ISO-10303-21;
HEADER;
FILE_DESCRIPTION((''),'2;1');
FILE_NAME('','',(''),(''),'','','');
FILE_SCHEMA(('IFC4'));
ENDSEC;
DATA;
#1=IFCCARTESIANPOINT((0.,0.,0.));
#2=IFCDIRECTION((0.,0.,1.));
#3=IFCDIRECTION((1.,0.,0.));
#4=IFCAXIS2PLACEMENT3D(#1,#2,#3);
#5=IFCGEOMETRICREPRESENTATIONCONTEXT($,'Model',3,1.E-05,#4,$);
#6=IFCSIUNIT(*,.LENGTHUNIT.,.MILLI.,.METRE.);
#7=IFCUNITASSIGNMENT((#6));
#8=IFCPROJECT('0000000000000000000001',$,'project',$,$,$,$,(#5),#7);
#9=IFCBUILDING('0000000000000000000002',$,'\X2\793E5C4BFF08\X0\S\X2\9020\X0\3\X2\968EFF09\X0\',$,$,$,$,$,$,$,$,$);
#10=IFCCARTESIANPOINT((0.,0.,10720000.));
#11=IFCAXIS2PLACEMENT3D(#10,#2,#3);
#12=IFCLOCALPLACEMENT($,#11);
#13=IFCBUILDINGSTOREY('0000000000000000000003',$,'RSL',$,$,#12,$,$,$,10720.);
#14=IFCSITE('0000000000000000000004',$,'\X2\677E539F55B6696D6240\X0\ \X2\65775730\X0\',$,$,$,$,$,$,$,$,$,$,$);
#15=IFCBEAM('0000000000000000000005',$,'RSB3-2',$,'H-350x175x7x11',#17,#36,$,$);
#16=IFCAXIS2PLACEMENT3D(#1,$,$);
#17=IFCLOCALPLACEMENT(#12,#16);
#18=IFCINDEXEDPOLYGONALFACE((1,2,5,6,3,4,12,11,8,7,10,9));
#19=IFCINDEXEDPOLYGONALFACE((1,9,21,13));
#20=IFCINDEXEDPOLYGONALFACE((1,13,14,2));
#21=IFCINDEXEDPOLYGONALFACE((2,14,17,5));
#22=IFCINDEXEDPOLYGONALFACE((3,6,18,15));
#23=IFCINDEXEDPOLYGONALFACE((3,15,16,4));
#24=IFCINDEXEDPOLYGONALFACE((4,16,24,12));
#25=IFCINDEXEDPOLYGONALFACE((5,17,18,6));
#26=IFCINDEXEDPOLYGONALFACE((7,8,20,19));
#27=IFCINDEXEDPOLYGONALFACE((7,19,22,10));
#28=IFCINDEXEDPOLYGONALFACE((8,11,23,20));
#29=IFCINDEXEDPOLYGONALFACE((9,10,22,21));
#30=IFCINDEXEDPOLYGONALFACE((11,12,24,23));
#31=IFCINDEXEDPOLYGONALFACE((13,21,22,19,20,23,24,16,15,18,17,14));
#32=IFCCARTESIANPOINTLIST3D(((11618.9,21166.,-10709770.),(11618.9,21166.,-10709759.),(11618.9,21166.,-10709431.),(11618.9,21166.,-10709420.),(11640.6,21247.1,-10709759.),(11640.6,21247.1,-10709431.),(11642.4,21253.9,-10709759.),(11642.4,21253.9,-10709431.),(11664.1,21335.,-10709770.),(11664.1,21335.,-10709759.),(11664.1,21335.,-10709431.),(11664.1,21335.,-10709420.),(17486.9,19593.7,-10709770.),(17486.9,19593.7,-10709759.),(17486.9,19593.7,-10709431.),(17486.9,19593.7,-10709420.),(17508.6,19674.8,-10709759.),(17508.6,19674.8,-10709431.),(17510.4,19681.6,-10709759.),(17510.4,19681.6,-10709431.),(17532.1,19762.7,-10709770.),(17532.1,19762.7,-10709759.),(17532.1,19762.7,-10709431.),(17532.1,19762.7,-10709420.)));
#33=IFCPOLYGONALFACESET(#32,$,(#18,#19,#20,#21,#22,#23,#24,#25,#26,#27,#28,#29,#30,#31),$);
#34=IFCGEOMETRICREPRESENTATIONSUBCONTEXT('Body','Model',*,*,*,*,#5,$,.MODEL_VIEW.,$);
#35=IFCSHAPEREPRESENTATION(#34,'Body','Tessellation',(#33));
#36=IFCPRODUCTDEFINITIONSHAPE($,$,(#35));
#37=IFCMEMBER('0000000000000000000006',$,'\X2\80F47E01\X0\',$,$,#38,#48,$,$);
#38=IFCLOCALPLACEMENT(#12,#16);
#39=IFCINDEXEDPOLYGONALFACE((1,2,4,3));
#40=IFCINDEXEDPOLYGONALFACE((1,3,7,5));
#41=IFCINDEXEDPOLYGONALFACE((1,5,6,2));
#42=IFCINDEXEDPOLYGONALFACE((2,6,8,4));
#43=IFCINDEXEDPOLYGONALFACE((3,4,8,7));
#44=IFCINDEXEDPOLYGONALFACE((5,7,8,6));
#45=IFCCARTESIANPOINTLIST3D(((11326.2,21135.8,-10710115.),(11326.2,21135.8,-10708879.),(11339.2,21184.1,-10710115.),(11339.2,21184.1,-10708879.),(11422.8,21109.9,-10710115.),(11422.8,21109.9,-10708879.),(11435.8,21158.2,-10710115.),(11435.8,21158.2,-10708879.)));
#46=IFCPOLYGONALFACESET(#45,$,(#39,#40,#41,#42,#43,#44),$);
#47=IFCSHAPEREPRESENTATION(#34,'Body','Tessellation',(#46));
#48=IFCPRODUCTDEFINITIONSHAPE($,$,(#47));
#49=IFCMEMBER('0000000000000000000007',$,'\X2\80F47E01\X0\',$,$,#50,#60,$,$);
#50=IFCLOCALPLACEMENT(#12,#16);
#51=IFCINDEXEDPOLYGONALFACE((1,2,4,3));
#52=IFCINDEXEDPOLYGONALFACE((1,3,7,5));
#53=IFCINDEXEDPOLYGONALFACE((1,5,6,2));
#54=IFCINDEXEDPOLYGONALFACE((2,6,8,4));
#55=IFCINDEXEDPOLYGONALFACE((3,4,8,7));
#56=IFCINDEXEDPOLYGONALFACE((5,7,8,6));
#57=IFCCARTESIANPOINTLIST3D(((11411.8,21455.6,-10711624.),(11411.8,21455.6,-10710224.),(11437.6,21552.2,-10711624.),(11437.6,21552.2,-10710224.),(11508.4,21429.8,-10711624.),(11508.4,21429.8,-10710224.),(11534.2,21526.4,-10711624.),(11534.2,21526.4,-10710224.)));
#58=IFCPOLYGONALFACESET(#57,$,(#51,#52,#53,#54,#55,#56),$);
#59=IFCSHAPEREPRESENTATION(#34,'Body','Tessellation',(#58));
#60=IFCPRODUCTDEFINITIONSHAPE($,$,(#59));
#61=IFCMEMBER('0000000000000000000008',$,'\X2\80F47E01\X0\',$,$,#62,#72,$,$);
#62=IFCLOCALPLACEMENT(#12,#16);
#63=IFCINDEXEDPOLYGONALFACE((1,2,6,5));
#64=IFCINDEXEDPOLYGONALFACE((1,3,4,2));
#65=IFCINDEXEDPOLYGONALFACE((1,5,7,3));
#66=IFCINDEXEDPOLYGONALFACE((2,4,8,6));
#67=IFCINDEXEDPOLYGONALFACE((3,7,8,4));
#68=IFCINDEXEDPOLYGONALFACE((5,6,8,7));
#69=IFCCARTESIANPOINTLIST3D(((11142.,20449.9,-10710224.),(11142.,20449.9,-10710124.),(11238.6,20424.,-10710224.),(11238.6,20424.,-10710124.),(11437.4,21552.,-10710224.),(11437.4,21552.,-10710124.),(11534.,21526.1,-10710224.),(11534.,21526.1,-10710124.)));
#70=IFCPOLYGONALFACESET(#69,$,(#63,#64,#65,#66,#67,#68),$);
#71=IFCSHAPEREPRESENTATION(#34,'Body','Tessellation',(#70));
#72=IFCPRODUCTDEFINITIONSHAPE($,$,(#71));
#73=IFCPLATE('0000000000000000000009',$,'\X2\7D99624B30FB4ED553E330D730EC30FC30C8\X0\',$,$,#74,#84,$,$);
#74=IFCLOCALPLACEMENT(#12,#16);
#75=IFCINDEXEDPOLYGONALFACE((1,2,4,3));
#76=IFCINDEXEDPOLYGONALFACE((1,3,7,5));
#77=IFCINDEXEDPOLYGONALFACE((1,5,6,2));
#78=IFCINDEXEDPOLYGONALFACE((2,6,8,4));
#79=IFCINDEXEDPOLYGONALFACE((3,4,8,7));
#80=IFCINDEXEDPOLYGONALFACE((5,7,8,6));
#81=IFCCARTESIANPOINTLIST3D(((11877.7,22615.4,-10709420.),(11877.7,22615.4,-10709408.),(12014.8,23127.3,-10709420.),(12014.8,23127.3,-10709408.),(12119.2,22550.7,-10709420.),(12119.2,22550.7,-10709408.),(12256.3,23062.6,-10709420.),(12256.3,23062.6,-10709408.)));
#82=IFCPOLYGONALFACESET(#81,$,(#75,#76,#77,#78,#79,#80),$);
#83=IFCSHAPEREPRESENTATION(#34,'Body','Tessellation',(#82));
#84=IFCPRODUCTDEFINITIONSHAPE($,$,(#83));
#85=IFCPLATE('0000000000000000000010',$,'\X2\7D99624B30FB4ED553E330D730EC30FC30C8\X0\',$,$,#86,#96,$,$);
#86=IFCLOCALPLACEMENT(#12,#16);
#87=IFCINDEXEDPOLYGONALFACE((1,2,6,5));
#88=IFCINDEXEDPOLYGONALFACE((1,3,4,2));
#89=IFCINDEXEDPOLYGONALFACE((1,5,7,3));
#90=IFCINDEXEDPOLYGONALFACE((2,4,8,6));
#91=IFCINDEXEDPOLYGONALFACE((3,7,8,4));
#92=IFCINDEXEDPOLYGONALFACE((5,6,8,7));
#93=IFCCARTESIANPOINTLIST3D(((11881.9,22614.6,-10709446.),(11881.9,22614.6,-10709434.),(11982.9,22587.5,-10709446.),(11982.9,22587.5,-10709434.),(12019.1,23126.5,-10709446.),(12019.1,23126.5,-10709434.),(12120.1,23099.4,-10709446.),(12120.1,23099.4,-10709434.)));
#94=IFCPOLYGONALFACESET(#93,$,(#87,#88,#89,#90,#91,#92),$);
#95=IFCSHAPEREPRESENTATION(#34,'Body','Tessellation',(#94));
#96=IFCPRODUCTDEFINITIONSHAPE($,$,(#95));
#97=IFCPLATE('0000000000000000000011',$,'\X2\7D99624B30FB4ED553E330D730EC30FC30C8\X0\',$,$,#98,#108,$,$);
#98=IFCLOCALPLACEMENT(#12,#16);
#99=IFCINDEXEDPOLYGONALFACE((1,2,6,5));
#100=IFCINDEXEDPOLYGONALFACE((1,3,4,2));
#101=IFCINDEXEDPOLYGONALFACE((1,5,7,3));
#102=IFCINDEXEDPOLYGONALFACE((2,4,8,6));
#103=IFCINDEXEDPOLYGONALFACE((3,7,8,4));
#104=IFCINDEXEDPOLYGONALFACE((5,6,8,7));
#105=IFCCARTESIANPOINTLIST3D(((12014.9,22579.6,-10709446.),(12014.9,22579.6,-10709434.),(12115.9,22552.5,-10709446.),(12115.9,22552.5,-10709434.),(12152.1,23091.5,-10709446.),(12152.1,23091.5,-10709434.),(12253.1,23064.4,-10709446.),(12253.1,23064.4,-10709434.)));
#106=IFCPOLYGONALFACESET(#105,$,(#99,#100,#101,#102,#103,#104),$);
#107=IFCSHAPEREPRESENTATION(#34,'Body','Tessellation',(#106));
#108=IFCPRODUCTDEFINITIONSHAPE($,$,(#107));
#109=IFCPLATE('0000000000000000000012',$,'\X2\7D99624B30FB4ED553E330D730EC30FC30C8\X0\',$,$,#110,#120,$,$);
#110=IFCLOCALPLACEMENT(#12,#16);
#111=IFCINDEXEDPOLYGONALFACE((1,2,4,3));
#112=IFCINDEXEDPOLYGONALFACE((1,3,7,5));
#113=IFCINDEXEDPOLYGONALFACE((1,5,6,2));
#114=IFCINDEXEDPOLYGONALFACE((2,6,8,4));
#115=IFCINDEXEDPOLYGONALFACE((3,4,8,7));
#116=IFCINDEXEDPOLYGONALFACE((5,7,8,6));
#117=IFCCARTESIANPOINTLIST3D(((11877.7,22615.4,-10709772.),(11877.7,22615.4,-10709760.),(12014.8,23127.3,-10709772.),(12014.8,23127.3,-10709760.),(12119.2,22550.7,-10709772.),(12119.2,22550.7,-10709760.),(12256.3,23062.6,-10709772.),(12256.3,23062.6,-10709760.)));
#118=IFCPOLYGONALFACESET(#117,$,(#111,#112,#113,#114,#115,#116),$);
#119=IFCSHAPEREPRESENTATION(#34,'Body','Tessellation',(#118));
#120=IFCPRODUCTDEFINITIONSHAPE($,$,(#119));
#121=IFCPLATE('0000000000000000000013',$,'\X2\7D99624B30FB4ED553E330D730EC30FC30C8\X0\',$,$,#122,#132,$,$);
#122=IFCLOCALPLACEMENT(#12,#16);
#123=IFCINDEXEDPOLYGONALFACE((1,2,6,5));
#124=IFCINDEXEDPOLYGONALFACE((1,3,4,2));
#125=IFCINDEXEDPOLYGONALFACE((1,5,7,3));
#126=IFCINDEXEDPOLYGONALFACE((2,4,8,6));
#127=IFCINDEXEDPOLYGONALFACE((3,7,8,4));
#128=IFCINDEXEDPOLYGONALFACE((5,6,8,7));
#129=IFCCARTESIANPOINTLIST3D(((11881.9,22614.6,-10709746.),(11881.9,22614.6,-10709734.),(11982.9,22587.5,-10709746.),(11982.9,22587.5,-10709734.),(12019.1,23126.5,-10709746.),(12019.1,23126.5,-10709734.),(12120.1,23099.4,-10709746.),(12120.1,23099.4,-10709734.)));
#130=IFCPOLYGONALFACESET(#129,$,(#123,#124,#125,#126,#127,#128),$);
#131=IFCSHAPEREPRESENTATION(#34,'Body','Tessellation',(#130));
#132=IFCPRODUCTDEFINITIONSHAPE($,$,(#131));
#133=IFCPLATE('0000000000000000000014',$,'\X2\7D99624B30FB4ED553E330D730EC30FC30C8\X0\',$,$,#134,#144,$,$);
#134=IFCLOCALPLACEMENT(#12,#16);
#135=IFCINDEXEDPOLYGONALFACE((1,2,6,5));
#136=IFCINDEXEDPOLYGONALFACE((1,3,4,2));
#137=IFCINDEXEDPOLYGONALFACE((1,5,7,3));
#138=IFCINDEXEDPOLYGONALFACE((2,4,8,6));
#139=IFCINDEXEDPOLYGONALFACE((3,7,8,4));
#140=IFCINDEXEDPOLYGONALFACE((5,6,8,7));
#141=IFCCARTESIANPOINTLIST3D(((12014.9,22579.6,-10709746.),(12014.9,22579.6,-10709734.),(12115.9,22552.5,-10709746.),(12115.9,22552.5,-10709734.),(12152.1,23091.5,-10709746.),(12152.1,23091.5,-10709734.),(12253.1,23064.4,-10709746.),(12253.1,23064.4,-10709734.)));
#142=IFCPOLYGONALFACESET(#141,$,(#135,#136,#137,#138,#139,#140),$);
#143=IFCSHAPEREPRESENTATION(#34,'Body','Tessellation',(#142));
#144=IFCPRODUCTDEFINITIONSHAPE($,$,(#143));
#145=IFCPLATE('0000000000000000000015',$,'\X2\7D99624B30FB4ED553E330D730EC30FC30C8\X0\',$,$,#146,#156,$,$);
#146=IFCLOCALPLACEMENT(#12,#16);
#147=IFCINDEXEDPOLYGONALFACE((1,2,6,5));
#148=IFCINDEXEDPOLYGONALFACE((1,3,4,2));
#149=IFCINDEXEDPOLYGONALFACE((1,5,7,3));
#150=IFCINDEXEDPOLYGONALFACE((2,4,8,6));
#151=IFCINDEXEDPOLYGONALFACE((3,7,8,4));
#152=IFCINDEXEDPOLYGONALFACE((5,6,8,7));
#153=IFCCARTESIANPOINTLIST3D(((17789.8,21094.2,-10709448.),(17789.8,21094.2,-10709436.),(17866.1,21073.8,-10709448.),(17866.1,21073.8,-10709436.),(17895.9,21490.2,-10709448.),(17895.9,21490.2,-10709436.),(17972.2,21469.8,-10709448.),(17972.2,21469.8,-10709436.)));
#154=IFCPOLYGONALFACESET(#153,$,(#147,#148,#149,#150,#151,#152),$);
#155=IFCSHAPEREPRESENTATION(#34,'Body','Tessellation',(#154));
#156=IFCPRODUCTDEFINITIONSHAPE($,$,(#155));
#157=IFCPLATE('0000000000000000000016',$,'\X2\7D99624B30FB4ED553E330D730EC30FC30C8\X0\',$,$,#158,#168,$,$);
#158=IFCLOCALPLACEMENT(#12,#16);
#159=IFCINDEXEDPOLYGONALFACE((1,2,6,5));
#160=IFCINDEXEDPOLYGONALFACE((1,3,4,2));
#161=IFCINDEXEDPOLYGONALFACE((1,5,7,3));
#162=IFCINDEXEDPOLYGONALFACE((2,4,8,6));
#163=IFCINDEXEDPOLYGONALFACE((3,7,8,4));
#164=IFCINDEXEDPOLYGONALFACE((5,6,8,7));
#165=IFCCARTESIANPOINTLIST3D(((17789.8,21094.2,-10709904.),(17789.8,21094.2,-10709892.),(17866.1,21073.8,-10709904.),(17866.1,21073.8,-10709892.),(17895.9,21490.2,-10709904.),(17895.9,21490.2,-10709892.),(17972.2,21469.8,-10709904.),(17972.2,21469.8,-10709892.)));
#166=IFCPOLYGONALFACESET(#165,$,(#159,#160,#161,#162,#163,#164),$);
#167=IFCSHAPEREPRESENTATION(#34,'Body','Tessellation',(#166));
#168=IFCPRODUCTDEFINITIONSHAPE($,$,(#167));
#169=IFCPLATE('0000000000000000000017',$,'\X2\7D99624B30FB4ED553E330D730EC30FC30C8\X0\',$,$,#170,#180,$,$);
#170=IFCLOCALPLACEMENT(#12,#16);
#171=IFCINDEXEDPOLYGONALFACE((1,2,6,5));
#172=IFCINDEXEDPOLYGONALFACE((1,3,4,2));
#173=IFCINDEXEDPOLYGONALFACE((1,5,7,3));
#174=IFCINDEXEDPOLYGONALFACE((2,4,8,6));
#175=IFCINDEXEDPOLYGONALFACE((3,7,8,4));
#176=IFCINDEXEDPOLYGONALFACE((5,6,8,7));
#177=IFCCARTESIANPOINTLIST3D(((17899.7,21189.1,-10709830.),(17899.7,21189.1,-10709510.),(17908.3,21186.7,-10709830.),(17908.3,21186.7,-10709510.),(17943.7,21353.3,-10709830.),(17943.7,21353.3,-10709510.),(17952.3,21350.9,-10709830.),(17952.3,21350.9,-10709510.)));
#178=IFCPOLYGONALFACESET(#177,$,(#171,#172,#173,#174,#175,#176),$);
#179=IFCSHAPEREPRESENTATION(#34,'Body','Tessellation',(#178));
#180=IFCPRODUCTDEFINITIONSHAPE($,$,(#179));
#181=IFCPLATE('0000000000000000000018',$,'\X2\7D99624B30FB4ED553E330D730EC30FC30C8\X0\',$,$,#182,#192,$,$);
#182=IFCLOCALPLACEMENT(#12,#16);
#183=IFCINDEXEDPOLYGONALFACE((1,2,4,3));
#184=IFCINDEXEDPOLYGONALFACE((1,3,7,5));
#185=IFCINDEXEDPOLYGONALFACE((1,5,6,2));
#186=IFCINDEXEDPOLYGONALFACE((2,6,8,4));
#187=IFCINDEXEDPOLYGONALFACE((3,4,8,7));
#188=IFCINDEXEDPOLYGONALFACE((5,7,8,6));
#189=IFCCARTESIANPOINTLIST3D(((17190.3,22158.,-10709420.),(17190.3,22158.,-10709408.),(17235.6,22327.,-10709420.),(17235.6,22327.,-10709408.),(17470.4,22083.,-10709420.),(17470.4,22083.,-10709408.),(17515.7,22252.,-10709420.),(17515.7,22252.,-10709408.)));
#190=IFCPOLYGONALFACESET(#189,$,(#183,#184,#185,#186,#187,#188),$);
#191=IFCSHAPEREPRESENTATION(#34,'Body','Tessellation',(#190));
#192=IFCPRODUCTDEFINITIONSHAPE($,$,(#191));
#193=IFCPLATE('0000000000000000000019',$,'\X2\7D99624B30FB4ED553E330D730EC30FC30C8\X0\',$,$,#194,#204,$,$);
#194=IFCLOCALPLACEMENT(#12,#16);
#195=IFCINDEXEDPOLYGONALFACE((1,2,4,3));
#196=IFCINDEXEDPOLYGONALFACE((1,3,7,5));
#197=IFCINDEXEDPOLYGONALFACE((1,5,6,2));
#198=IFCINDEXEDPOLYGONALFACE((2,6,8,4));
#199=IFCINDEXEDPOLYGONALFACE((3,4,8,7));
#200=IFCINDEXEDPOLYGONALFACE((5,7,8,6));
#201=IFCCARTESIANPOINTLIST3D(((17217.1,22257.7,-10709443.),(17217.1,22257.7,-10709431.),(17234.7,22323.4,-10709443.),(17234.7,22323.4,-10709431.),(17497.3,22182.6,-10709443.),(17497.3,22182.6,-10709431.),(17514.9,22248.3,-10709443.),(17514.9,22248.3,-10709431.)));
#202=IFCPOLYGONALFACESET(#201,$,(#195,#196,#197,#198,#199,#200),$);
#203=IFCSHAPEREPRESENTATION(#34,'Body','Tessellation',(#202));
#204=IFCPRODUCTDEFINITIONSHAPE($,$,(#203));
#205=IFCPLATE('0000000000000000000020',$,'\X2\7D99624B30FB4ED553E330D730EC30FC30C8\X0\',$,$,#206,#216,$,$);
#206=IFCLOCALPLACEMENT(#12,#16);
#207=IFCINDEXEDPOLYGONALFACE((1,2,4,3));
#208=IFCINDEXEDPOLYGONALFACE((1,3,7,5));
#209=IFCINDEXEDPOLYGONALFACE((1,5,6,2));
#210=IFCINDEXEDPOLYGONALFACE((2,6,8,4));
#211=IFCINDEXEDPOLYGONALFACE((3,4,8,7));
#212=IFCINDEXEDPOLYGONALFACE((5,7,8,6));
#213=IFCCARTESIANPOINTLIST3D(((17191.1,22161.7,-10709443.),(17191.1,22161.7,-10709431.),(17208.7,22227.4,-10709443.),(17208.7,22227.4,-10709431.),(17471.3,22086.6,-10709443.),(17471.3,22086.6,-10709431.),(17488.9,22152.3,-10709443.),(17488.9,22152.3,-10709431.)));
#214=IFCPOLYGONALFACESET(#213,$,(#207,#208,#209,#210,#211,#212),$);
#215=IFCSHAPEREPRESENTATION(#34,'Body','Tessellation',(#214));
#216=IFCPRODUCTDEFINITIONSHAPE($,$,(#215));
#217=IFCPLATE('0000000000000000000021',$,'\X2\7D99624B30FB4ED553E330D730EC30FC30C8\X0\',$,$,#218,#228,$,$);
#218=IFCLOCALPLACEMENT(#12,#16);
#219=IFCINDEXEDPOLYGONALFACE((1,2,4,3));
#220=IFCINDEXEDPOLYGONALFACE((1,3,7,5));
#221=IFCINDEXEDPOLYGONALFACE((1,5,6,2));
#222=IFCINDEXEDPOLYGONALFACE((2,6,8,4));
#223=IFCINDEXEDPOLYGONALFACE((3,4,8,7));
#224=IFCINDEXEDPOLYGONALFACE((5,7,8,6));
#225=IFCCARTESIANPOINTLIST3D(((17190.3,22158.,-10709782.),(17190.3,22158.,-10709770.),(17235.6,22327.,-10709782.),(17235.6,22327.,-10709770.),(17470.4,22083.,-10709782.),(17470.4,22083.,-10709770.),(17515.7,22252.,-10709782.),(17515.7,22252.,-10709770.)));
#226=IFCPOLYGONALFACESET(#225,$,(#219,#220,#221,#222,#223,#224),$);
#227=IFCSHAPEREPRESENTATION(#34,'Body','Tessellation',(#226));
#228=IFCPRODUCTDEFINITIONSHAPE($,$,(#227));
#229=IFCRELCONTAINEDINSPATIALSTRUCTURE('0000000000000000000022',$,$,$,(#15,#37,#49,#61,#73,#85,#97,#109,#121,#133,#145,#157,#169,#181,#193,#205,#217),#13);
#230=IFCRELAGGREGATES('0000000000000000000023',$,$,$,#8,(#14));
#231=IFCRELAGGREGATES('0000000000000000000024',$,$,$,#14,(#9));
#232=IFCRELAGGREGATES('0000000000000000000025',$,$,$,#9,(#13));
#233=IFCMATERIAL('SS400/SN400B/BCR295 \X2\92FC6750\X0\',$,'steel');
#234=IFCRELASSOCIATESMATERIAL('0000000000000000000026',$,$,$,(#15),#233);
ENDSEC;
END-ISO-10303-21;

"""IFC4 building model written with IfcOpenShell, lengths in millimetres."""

from ifc_helpers import new_model, si_unit, frame, origin, origin_with_axes, place, context, subcontext, project, spatial, rectangle, i_section, extrude, material, element, save


model = new_model("IFC4")

# Units and contexts
model_context = context("Model", 3, precision=1e-05, world=origin_with_axes())
body_context = subcontext(model_context, "Body", "Model", "MODEL_VIEW")
ifc_project = project(units=[si_unit("LENGTHUNIT", "METRE", prefix="MILLI")], contexts=[model_context])

# Site, building, storey
site = spatial("IfcSite", under=ifc_project, Name="松原営業所 敷地")
building = spatial("IfcBuilding", under=site, Name="社屋（S造3階）")
storey_placement = place(None, frame((0.0, 0.0, 10720000.0), z_axis=(0.0, 0.0, 1.0), x_axis=(1.0, 0.0, 0.0)))
storey = spatial("IfcBuildingStorey", under=building, at=storey_placement, Name="RSL", Elevation=10720.0)

# Beam
ifc_material = material(Name="SS400/SN400B/BCR295 鋼材", Category="steel")
beam_placement = place(storey_placement, frame((11641.5, 21250.5, -10709420.0), z_axis=(0.965927, -0.258815, 0.0), x_axis=(0.258815, 0.965927, 0.0)))
element("IfcBeam", 1, at=beam_placement, inside=storey, material=ifc_material, Name="RSB3-2", ObjectType="H-350x175x7x11", context=body_context, shape_type="SweptSolid", body=[
    extrude(i_section(OverallWidth=175.0, OverallDepth=350.0, WebThickness=7.0, FlangeThickness=11.0), frame((0.0, -175.0, 0.0)), (0.0, 0.0, 1.0), 6075.0),
])

# Members
member_1_placement = place(storey_placement, frame((11387.5, 21171.1, -10709497.0), z_axis=(-0.258819, -0.965926, 0.0), x_axis=(0.965926, -0.258819, 0.0)))
element("IfcMember", 2, at=member_1_placement, inside=storey, Name="胴縁", context=body_context, shape_type="SweptSolid", body=[
    extrude(rectangle(XDim=100.0, YDim=1236.0), origin(), (0.0, 0.0, 1.0), 50.0),
])
member_2_placement = place(storey_placement, frame((11485.9, 21539.3, -10710924.0), z_axis=(-0.258819, -0.965926, 0.0), x_axis=(0.965926, -0.258819, 0.0)))
element("IfcMember", 3, at=member_2_placement, inside=storey, Name="胴縁", context=body_context, shape_type="SweptSolid", body=[
    extrude(rectangle(XDim=100.0, YDim=1400.0), origin(), (0.0, 0.0, 1.0), 100.0),
])
member_3_placement = place(storey_placement, frame((11485.7, 21539.1, -10710174.0), z_axis=(-0.258819, -0.965926, 0.0), x_axis=(0.965926, -0.258819, 0.0)))
element("IfcMember", 4, at=member_3_placement, inside=storey, Name="胴縁", context=body_context, shape_type="SweptSolid", body=[
    extrude(rectangle(XDim=100.0, YDim=100.0), origin(), (0.0, 0.0, 1.0), 1141.0),
])

# Plates
plate_1_placement = place(storey_placement, frame((11998.4, 22583.0, -10709414.0), z_axis=(0.258819, 0.965926, 0.0), x_axis=(-0.965926, 0.258819, 0.0)))
element("IfcPlate", 5, at=plate_1_placement, inside=storey, Name="継手・仕口プレート", context=body_context, shape_type="SweptSolid", body=[
    extrude(rectangle(XDim=250.0, YDim=12.0), origin(), (0.0, 0.0, 1.0), 530.0),
])
for number, where, z_axis, x_axis, name in (
    (6, (11932.4, 22601.0, -10709440.0), (0.258819, 0.965926, 0.0), (-0.965926, 0.258819, 0.0), "継手・仕口プレート"),
    (7, (12065.4, 22566.0, -10709440.0), (0.258819, 0.965926, 0.0), (-0.965926, 0.258819, 0.0), "継手・仕口プレート"),
):
    element("IfcPlate", number, at=place(storey_placement, frame(where, z_axis=z_axis, x_axis=x_axis)), inside=storey, Name=name, context=body_context, shape_type="SweptSolid", body=[
        extrude(rectangle(XDim=104.5, YDim=12.0), origin(), (0.0, 0.0, 1.0), 530.0),
    ])
plate_2_placement = place(storey_placement, frame((11998.4, 22583.0, -10709766.0), z_axis=(0.258819, 0.965926, 0.0), x_axis=(-0.965926, 0.258819, 0.0)))
element("IfcPlate", 8, at=plate_2_placement, inside=storey, Name="継手・仕口プレート", context=body_context, shape_type="SweptSolid", body=[
    extrude(rectangle(XDim=250.0, YDim=12.0), origin(), (0.0, 0.0, 1.0), 530.0),
])
for number, where, z_axis, x_axis, name in (
    (9, (11932.4, 22601.0, -10709740.0), (0.258819, 0.965926, 0.0), (-0.965926, 0.258819, 0.0), "継手・仕口プレート"),
    (10, (12065.4, 22566.0, -10709740.0), (0.258819, 0.965926, 0.0), (-0.965926, 0.258819, 0.0), "継手・仕口プレート"),
):
    element("IfcPlate", number, at=place(storey_placement, frame(where, z_axis=z_axis, x_axis=x_axis)), inside=storey, Name=name, context=body_context, shape_type="SweptSolid", body=[
        extrude(rectangle(XDim=104.5, YDim=12.0), origin(), (0.0, 0.0, 1.0), 530.0),
    ])
for number, where, z_axis, x_axis, name in (
    (11, (17827.9, 21084.0, -10709442.0), (0.258819, 0.965926, 0.0), (-0.965926, 0.258819, 0.0), "継手・仕口プレート"),
    (12, (17827.9, 21084.0, -10709898.0), (0.258819, 0.965926, 0.0), (-0.965926, 0.258819, 0.0), "継手・仕口プレート"),
):
    element("IfcPlate", number, at=place(storey_placement, frame(where, z_axis=z_axis, x_axis=x_axis)), inside=storey, Name=name, context=body_context, shape_type="SweptSolid", body=[
        extrude(rectangle(XDim=79.0, YDim=12.0), origin(), (0.0, 0.0, 1.0), 410.0),
    ])
plate_3_placement = place(storey_placement, frame((17904.0, 21187.9, -10709670.0), z_axis=(0.258819, 0.965926, 0.0), x_axis=(-0.965926, 0.258819, 0.0)))
element("IfcPlate", 13, at=plate_3_placement, inside=storey, Name="継手・仕口プレート", context=body_context, shape_type="SweptSolid", body=[
    extrude(rectangle(XDim=9.0, YDim=320.0), origin(), (0.0, 0.0, 1.0), 170.0),
])
plate_4_placement = place(storey_placement, frame((17212.9, 22242.5, -10709414.0), z_axis=(0.965926, -0.258819, 0.0), x_axis=(0.258819, 0.965926, 0.0)))
element("IfcPlate", 14, at=plate_4_placement, inside=storey, Name="継手・仕口プレート", context=body_context, shape_type="SweptSolid", body=[
    extrude(rectangle(XDim=175.0, YDim=12.0), origin(), (0.0, 0.0, 1.0), 290.0),
])
for number, where, z_axis, x_axis, name in (
    (15, (17225.9, 22290.5, -10709437.0), (0.965926, -0.258819, 0.0), (0.258819, 0.965926, 0.0), "継手・仕口プレート"),
    (16, (17199.9, 22194.5, -10709437.0), (0.965926, -0.258819, 0.0), (0.258819, 0.965926, 0.0), "継手・仕口プレート"),
):
    element("IfcPlate", number, at=place(storey_placement, frame(where, z_axis=z_axis, x_axis=x_axis)), inside=storey, Name=name, context=body_context, shape_type="SweptSolid", body=[
        extrude(rectangle(XDim=68.0, YDim=12.0), origin(), (0.0, 0.0, 1.0), 290.0),
    ])
plate_5_placement = place(storey_placement, frame((17212.9, 22242.5, -10709776.0), z_axis=(0.965926, -0.258819, 0.0), x_axis=(0.258819, 0.965926, 0.0)))
element("IfcPlate", 17, at=plate_5_placement, inside=storey, Name="継手・仕口プレート", context=body_context, shape_type="SweptSolid", body=[
    extrude(rectangle(XDim=175.0, YDim=12.0), origin(), (0.0, 0.0, 1.0), 290.0),
])

save(model, "model.ifc")
